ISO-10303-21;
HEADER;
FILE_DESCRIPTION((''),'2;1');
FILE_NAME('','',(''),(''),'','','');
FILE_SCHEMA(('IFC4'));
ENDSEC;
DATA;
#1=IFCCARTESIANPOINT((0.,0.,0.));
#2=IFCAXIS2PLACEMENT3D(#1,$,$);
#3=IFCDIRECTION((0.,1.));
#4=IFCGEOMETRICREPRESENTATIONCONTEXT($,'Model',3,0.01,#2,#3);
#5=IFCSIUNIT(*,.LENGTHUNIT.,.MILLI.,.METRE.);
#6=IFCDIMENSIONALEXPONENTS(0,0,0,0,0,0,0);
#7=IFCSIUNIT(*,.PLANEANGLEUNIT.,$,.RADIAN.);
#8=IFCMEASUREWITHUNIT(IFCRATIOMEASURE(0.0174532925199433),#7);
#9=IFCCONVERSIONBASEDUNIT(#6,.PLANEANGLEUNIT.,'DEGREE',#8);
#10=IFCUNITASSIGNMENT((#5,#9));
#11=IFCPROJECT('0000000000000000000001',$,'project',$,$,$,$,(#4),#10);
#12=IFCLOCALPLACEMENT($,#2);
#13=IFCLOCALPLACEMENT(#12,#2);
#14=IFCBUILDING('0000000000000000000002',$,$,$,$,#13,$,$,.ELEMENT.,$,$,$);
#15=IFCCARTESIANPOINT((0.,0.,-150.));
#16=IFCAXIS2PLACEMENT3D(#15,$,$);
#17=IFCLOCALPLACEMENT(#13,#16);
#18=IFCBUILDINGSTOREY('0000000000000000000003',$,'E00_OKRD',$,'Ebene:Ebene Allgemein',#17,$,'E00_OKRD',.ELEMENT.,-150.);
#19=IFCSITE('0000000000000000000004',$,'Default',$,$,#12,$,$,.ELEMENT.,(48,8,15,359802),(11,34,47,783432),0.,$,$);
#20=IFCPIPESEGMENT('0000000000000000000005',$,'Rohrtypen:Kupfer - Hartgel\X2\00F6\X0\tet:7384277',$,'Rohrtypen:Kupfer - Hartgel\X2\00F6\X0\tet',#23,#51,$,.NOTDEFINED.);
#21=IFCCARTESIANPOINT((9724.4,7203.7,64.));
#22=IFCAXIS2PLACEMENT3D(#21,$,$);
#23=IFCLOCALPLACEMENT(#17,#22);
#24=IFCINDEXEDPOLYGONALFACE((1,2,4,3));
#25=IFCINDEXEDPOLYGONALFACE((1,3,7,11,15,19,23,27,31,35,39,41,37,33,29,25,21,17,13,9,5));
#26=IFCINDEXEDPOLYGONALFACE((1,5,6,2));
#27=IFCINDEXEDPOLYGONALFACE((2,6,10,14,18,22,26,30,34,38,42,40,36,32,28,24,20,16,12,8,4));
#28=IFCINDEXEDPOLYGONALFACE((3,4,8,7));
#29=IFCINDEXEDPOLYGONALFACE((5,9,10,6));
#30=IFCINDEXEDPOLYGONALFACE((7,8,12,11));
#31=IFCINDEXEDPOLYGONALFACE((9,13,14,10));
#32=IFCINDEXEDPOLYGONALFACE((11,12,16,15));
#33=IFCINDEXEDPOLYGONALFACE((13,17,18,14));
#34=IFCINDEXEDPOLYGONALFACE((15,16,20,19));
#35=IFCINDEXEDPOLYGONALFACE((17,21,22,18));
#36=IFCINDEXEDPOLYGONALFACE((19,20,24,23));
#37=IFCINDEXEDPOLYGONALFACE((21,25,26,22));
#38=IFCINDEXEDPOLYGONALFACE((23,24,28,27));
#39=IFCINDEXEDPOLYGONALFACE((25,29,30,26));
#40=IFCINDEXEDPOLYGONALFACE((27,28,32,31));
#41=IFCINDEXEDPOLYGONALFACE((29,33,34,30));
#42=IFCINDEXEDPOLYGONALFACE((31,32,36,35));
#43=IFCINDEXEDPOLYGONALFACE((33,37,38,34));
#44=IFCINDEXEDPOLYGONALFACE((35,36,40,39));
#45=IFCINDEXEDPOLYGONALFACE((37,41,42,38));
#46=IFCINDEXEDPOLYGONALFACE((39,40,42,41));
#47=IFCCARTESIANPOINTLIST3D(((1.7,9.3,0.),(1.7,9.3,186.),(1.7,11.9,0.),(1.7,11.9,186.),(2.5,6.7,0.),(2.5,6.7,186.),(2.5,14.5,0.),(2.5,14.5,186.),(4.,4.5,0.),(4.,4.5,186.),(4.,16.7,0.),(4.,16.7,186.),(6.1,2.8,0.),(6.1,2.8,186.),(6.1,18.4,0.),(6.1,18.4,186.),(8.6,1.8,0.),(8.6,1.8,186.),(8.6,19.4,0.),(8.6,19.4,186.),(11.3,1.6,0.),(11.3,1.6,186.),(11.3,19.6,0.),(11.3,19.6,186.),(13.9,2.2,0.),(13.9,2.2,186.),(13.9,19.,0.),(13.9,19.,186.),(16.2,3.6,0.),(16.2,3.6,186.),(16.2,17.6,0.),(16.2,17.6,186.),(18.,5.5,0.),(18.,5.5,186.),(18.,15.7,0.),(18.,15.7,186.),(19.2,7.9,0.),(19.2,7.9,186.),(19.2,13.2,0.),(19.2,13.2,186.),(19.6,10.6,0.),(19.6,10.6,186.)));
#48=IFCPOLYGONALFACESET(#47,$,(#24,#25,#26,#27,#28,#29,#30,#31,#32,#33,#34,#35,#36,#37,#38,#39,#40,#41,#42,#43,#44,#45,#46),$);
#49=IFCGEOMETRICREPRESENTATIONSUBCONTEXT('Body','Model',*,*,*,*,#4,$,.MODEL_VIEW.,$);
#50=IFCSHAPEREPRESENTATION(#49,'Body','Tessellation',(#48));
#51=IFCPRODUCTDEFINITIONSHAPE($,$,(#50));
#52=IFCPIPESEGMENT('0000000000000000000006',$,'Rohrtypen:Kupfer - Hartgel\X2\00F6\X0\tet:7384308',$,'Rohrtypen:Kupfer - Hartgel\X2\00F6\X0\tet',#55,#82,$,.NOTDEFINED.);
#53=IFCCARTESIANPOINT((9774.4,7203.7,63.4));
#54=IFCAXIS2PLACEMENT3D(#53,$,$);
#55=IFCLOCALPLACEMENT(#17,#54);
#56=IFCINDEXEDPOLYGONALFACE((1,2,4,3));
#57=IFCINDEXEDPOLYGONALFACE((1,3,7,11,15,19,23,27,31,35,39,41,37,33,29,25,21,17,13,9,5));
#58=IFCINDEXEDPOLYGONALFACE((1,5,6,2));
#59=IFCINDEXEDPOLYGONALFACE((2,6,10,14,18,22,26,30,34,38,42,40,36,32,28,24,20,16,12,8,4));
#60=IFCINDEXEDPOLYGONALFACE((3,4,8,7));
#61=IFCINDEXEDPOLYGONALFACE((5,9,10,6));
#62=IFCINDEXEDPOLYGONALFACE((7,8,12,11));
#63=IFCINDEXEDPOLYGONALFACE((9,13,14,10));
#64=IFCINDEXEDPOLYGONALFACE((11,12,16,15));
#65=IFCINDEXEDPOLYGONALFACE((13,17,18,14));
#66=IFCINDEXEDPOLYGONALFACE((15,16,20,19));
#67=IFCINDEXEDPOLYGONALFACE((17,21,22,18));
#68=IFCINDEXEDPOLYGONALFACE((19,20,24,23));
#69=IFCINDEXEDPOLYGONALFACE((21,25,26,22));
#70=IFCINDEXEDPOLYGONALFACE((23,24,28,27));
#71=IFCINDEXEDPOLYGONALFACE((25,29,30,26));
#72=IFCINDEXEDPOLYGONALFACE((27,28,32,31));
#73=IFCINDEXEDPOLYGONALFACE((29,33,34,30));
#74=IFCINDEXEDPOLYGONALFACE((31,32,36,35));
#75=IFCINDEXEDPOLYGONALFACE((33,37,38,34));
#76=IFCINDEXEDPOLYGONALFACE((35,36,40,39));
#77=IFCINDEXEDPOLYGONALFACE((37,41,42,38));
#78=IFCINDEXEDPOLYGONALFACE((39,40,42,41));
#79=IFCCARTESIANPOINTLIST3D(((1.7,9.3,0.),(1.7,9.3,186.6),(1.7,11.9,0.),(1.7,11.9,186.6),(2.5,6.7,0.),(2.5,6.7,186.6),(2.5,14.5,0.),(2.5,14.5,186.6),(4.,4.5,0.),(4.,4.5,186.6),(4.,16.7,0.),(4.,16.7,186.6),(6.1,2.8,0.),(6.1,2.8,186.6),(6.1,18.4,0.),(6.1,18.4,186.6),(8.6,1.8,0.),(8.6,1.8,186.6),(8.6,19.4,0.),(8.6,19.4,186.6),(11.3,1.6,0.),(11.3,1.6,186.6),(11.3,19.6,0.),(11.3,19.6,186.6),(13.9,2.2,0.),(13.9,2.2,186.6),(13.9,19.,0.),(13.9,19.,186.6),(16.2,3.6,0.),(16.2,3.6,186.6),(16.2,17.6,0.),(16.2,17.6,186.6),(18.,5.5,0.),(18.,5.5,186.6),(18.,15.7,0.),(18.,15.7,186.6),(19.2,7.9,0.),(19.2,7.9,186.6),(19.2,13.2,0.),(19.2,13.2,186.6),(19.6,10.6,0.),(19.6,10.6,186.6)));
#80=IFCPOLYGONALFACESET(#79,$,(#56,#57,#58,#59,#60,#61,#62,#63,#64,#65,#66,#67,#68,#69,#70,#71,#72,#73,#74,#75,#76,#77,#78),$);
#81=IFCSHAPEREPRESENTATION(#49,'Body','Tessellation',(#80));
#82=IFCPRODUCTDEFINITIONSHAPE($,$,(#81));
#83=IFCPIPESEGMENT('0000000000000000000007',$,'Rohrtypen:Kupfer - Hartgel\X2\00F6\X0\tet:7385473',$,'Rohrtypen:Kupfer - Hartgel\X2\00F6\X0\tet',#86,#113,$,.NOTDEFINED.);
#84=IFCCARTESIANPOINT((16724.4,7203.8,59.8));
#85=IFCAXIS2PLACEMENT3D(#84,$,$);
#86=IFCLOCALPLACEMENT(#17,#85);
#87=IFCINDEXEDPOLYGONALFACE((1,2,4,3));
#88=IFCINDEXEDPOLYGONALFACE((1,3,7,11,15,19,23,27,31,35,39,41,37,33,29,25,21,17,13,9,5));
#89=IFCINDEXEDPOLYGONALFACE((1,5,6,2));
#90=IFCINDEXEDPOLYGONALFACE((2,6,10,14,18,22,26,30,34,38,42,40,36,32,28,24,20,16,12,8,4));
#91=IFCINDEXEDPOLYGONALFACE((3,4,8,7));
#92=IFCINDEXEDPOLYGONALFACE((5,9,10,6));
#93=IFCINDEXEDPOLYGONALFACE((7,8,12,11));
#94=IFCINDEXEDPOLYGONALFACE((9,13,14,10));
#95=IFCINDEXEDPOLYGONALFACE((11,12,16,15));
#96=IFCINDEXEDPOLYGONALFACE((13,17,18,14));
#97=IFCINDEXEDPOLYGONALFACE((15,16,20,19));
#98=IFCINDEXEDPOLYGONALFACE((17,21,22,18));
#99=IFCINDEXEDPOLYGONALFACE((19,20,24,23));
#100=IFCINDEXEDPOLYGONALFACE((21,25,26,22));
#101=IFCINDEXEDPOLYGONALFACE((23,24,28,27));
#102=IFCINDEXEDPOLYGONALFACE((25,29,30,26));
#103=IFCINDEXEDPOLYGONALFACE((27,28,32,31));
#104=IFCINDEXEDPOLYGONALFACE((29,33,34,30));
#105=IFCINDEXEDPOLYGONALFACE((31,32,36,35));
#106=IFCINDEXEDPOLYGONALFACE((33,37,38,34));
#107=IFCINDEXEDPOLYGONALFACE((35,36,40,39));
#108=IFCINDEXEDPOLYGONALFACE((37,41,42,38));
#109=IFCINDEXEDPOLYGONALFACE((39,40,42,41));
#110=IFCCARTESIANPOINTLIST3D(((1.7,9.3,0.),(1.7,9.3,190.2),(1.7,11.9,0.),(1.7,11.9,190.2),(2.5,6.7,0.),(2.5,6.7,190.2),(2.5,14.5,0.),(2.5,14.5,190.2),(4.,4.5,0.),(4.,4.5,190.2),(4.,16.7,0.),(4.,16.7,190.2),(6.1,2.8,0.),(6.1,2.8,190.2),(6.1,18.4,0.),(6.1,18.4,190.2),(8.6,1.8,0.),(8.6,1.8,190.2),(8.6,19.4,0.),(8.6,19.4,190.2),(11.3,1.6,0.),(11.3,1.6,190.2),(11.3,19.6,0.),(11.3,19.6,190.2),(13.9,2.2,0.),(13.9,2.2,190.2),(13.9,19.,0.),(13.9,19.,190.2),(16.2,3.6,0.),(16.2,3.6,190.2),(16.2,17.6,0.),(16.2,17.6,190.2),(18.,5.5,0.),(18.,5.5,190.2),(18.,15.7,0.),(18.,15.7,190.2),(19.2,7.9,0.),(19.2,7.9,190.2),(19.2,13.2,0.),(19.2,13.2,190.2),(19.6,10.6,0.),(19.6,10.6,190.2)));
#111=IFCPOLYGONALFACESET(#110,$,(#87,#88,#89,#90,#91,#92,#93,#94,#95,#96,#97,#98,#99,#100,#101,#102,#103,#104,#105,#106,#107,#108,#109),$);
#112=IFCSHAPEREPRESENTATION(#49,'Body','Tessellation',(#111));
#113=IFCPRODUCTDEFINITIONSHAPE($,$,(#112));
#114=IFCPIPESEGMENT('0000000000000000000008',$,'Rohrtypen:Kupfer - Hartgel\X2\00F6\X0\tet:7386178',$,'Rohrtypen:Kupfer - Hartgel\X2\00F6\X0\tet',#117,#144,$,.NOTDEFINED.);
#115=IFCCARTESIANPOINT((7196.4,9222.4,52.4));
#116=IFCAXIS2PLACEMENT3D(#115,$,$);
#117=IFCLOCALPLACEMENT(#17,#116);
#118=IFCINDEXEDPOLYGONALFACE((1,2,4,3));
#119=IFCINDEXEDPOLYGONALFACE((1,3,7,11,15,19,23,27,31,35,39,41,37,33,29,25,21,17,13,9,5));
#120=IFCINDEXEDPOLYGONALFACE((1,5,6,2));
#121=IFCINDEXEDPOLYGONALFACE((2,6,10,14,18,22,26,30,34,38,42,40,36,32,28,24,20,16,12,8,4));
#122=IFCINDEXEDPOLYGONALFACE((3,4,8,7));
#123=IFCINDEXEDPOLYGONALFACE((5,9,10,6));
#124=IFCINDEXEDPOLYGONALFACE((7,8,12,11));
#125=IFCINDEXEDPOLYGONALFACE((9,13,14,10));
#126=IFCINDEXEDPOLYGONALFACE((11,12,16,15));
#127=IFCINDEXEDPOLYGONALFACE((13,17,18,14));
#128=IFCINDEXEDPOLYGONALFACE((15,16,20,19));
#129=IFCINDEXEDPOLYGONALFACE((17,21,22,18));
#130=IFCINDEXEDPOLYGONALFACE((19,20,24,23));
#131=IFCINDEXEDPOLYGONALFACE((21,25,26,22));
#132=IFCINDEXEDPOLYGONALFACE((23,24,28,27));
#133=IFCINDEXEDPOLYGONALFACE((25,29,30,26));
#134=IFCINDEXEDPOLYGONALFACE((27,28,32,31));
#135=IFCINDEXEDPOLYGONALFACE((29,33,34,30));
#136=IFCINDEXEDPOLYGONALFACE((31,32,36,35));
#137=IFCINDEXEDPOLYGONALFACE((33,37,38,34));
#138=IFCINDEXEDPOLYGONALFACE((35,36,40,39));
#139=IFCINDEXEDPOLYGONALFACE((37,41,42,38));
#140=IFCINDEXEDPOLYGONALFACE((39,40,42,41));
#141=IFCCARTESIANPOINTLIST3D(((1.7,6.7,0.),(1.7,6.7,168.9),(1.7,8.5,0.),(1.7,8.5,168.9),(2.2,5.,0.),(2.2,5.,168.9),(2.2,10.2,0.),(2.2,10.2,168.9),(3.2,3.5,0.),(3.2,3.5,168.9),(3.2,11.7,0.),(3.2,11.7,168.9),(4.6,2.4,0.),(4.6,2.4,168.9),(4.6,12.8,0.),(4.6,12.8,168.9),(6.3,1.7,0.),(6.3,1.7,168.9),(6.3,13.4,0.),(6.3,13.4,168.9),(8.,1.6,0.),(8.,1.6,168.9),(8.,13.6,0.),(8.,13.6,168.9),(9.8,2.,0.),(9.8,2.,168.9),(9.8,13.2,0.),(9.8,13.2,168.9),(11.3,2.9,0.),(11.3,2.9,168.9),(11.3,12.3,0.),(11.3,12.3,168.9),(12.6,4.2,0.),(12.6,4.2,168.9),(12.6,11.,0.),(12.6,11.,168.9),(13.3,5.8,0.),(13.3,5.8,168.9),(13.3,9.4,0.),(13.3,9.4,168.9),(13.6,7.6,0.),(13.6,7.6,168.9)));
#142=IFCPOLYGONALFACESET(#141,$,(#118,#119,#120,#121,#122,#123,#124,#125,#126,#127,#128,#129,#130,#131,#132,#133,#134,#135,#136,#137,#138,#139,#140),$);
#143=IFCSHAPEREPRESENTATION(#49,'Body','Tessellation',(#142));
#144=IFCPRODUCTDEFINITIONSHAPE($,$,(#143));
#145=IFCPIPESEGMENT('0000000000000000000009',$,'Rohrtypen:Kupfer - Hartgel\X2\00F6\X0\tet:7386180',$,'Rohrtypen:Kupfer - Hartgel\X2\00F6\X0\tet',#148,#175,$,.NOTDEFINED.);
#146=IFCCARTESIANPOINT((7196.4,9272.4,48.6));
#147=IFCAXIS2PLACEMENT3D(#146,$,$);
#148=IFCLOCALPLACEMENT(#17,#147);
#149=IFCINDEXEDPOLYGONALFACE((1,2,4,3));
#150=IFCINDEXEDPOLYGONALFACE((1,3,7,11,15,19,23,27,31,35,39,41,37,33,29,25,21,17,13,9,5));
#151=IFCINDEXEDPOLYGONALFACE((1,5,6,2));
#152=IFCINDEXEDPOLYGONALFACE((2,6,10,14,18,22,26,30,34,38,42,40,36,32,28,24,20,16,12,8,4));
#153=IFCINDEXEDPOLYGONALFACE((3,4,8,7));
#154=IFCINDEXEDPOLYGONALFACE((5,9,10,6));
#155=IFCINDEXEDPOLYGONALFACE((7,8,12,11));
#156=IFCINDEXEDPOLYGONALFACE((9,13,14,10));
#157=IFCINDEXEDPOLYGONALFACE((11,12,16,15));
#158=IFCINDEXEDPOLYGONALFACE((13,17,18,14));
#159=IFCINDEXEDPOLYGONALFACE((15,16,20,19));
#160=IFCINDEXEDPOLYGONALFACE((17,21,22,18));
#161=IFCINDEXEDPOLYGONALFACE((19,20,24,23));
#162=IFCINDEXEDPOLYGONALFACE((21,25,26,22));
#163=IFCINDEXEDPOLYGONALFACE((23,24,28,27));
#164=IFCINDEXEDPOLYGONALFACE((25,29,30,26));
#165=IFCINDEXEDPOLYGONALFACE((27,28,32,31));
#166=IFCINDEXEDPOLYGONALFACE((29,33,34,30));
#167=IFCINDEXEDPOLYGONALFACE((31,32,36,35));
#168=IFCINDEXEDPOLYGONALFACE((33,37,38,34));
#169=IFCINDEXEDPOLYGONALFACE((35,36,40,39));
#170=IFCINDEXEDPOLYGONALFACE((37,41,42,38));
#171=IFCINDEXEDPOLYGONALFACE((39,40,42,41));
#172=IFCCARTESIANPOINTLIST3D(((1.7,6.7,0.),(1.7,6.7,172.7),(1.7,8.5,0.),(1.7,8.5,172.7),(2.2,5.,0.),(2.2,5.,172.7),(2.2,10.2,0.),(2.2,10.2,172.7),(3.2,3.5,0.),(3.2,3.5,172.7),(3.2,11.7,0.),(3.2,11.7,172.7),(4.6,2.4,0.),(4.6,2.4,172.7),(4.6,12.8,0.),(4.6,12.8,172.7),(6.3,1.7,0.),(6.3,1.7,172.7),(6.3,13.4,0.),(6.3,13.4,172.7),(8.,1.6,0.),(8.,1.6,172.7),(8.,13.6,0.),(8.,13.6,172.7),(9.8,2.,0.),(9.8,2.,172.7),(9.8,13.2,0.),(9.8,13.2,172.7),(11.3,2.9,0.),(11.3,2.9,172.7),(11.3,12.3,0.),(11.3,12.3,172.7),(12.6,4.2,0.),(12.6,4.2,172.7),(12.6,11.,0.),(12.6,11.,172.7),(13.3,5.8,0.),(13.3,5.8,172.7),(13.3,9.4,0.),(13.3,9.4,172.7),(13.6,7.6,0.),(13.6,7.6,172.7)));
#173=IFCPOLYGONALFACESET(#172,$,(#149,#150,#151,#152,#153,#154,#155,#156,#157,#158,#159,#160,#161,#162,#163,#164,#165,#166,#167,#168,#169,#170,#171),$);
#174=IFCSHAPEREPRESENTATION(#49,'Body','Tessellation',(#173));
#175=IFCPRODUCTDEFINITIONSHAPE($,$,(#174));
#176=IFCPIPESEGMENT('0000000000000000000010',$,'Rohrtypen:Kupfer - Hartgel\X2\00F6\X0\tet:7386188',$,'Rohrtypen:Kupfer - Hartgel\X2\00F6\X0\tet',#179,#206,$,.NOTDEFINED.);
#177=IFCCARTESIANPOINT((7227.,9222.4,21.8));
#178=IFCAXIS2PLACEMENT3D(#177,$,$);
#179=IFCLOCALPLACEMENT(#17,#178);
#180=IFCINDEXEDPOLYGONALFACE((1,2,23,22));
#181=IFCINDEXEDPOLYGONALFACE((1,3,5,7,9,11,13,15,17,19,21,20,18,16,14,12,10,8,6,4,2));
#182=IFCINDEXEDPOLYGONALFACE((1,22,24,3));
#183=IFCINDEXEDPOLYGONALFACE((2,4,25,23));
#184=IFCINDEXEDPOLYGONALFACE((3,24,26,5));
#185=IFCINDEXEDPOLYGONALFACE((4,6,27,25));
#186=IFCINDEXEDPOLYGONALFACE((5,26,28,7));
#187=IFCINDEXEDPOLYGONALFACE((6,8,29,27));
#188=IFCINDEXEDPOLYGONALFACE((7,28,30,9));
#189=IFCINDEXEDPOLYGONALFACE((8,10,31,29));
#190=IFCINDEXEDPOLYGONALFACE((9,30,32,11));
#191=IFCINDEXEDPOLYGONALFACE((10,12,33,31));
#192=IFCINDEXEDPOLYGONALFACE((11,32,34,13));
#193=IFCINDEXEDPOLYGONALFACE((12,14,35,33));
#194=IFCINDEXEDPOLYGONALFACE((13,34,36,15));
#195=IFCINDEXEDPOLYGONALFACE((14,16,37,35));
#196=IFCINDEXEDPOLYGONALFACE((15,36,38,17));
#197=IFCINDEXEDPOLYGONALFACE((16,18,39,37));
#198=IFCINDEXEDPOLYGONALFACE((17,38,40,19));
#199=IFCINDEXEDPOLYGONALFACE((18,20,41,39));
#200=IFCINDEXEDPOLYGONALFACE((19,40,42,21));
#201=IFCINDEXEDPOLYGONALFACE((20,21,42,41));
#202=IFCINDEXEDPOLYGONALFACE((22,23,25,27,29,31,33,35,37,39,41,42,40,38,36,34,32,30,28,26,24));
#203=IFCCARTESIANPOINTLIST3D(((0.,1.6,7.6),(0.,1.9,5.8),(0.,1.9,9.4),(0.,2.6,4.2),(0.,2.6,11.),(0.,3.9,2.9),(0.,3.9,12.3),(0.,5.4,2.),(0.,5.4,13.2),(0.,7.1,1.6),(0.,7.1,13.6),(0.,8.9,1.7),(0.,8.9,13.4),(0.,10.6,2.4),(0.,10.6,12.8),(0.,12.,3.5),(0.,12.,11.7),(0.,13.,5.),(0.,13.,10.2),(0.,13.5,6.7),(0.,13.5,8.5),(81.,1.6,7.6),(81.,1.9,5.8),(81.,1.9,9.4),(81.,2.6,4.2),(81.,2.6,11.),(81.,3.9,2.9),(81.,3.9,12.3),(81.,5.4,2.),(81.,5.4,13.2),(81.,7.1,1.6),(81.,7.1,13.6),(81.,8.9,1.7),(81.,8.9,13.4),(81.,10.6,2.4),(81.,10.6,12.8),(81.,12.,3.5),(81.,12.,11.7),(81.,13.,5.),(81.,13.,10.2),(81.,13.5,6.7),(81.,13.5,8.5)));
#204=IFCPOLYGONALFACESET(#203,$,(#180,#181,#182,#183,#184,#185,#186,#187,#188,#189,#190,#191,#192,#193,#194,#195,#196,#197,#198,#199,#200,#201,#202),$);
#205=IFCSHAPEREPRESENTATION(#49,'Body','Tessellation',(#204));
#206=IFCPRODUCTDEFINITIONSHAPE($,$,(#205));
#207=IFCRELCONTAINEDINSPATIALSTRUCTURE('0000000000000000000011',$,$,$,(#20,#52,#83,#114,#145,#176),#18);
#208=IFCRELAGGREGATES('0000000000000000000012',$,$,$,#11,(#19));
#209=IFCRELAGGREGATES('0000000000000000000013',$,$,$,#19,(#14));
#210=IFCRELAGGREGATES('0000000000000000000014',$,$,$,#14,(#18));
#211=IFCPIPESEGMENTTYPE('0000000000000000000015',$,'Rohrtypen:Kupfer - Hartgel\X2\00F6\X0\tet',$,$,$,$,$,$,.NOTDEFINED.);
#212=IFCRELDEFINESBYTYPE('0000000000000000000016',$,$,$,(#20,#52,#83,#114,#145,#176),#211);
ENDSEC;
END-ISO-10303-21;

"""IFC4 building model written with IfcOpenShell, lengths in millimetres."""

from ifc_helpers import new_model, entity, si_unit, converted_unit, direction, frame, frame_2d, origin, origin_2d_with_axis, place, context, subcontext, project, spatial, circle, extrude, type_object, element, save


model = new_model("IFC4")

# Units and contexts
model_context = context("Model", 3, precision=0.01, world=origin(), true_north=direction((0.0, 1.0)))
body_context = subcontext(model_context, "Body", "Model", "MODEL_VIEW")
ifc_project = project(units=[si_unit("LENGTHUNIT", "METRE", prefix="MILLI"), converted_unit("PLANEANGLEUNIT", "DEGREE", entity("IfcRatioMeasure", 0.0174532925199433), si_unit("PLANEANGLEUNIT", "RADIAN"), dimensions=[0, 0, 0, 0, 0, 0, 0])], contexts=[model_context])

# Site, building, storey
site_placement = place(None, origin())
site = spatial("IfcSite", under=ifc_project, at=site_placement, Name="Default", CompositionType="ELEMENT", RefLatitude=(48, 8, 15, 359802), RefLongitude=(11, 34, 47, 783432), RefElevation=0.0)
building_placement = place(site_placement, origin())
building = spatial("IfcBuilding", under=site, at=building_placement, CompositionType="ELEMENT")
storey_placement = place(building_placement, frame((0.0, 0.0, -150.0)))
storey = spatial("IfcBuildingStorey", under=building, at=storey_placement, Name="E00_OKRD", ObjectType="Ebene:Ebene Allgemein", LongName="E00_OKRD", CompositionType="ELEMENT", Elevation=-150.0)

# Pipe segments
pipe_segment_type = type_object("IfcPipeSegmentType", Name="Rohrtypen:Kupfer - Hartgelötet", PredefinedType="NOTDEFINED")
pipe_segment_1_placement = place(storey_placement, frame((9724.4, 7203.7, 64.0)))
element("IfcPipeSegment", 1, at=pipe_segment_1_placement, inside=storey, type_object=pipe_segment_type, Name="Rohrtypen:Kupfer - Hartgelötet:7384277", ObjectType="Rohrtypen:Kupfer - Hartgelötet", PredefinedType="NOTDEFINED", context=body_context, shape_type="SweptSolid", body=[
    extrude(circle(Radius=9.0, at=origin_2d_with_axis()), frame((10.6, 10.6, 0.0)), (0.0, 0.0, 1.0), 186.0),
])
pipe_segment_2_placement = place(storey_placement, frame((9774.4, 7203.7, 63.4)))
element("IfcPipeSegment", 2, at=pipe_segment_2_placement, inside=storey, type_object=pipe_segment_type, Name="Rohrtypen:Kupfer - Hartgelötet:7384308", ObjectType="Rohrtypen:Kupfer - Hartgelötet", PredefinedType="NOTDEFINED", context=body_context, shape_type="SweptSolid", body=[
    extrude(circle(Radius=9.0, at=origin_2d_with_axis()), frame((10.6, 10.6, 0.0)), (0.0, 0.0, 1.0), 186.6),
])
pipe_segment_3_placement = place(storey_placement, frame((16724.4, 7203.8, 59.8)))
element("IfcPipeSegment", 3, at=pipe_segment_3_placement, inside=storey, type_object=pipe_segment_type, Name="Rohrtypen:Kupfer - Hartgelötet:7385473", ObjectType="Rohrtypen:Kupfer - Hartgelötet", PredefinedType="NOTDEFINED", context=body_context, shape_type="SweptSolid", body=[
    extrude(circle(Radius=9.0, at=origin_2d_with_axis()), frame((10.6, 10.6, 0.0)), (0.0, 0.0, 1.0), 190.2),
])
pipe_segment_4_placement = place(storey_placement, frame((7196.4, 9222.4, 52.4)))
element("IfcPipeSegment", 4, at=pipe_segment_4_placement, inside=storey, type_object=pipe_segment_type, Name="Rohrtypen:Kupfer - Hartgelötet:7386178", ObjectType="Rohrtypen:Kupfer - Hartgelötet", PredefinedType="NOTDEFINED", context=body_context, shape_type="SweptSolid", body=[
    extrude(circle(Radius=6.0, at=origin_2d_with_axis()), frame((7.6, 7.6, 0.0)), (0.0, 0.0, 1.0), 168.9),
])
pipe_segment_5_placement = place(storey_placement, frame((7196.4, 9272.4, 48.6)))
element("IfcPipeSegment", 5, at=pipe_segment_5_placement, inside=storey, type_object=pipe_segment_type, Name="Rohrtypen:Kupfer - Hartgelötet:7386180", ObjectType="Rohrtypen:Kupfer - Hartgelötet", PredefinedType="NOTDEFINED", context=body_context, shape_type="SweptSolid", body=[
    extrude(circle(Radius=6.0, at=frame_2d((0.0, 0.0), x_axis=(1.0, 0.0))), frame((7.6, 7.6, 0.0)), (0.0, 0.0, 1.0), 172.7),
])
pipe_segment_6_placement = place(storey_placement, frame((7227.0, 9222.4, 21.8)))
element("IfcPipeSegment", 6, at=pipe_segment_6_placement, inside=storey, type_object=pipe_segment_type, Name="Rohrtypen:Kupfer - Hartgelötet:7386188", ObjectType="Rohrtypen:Kupfer - Hartgelötet", PredefinedType="NOTDEFINED", context=body_context, shape_type="SweptSolid", body=[
    extrude(circle(Radius=6.0, at=origin_2d_with_axis()), frame((0.0, 7.6, 7.6), z_axis=(1.0, 0.0, 0.0), x_axis=(0.0, -1.0, 0.0)), (0.0, 0.0, 1.0), 81.0),
])

save(model, "model.ifc")
